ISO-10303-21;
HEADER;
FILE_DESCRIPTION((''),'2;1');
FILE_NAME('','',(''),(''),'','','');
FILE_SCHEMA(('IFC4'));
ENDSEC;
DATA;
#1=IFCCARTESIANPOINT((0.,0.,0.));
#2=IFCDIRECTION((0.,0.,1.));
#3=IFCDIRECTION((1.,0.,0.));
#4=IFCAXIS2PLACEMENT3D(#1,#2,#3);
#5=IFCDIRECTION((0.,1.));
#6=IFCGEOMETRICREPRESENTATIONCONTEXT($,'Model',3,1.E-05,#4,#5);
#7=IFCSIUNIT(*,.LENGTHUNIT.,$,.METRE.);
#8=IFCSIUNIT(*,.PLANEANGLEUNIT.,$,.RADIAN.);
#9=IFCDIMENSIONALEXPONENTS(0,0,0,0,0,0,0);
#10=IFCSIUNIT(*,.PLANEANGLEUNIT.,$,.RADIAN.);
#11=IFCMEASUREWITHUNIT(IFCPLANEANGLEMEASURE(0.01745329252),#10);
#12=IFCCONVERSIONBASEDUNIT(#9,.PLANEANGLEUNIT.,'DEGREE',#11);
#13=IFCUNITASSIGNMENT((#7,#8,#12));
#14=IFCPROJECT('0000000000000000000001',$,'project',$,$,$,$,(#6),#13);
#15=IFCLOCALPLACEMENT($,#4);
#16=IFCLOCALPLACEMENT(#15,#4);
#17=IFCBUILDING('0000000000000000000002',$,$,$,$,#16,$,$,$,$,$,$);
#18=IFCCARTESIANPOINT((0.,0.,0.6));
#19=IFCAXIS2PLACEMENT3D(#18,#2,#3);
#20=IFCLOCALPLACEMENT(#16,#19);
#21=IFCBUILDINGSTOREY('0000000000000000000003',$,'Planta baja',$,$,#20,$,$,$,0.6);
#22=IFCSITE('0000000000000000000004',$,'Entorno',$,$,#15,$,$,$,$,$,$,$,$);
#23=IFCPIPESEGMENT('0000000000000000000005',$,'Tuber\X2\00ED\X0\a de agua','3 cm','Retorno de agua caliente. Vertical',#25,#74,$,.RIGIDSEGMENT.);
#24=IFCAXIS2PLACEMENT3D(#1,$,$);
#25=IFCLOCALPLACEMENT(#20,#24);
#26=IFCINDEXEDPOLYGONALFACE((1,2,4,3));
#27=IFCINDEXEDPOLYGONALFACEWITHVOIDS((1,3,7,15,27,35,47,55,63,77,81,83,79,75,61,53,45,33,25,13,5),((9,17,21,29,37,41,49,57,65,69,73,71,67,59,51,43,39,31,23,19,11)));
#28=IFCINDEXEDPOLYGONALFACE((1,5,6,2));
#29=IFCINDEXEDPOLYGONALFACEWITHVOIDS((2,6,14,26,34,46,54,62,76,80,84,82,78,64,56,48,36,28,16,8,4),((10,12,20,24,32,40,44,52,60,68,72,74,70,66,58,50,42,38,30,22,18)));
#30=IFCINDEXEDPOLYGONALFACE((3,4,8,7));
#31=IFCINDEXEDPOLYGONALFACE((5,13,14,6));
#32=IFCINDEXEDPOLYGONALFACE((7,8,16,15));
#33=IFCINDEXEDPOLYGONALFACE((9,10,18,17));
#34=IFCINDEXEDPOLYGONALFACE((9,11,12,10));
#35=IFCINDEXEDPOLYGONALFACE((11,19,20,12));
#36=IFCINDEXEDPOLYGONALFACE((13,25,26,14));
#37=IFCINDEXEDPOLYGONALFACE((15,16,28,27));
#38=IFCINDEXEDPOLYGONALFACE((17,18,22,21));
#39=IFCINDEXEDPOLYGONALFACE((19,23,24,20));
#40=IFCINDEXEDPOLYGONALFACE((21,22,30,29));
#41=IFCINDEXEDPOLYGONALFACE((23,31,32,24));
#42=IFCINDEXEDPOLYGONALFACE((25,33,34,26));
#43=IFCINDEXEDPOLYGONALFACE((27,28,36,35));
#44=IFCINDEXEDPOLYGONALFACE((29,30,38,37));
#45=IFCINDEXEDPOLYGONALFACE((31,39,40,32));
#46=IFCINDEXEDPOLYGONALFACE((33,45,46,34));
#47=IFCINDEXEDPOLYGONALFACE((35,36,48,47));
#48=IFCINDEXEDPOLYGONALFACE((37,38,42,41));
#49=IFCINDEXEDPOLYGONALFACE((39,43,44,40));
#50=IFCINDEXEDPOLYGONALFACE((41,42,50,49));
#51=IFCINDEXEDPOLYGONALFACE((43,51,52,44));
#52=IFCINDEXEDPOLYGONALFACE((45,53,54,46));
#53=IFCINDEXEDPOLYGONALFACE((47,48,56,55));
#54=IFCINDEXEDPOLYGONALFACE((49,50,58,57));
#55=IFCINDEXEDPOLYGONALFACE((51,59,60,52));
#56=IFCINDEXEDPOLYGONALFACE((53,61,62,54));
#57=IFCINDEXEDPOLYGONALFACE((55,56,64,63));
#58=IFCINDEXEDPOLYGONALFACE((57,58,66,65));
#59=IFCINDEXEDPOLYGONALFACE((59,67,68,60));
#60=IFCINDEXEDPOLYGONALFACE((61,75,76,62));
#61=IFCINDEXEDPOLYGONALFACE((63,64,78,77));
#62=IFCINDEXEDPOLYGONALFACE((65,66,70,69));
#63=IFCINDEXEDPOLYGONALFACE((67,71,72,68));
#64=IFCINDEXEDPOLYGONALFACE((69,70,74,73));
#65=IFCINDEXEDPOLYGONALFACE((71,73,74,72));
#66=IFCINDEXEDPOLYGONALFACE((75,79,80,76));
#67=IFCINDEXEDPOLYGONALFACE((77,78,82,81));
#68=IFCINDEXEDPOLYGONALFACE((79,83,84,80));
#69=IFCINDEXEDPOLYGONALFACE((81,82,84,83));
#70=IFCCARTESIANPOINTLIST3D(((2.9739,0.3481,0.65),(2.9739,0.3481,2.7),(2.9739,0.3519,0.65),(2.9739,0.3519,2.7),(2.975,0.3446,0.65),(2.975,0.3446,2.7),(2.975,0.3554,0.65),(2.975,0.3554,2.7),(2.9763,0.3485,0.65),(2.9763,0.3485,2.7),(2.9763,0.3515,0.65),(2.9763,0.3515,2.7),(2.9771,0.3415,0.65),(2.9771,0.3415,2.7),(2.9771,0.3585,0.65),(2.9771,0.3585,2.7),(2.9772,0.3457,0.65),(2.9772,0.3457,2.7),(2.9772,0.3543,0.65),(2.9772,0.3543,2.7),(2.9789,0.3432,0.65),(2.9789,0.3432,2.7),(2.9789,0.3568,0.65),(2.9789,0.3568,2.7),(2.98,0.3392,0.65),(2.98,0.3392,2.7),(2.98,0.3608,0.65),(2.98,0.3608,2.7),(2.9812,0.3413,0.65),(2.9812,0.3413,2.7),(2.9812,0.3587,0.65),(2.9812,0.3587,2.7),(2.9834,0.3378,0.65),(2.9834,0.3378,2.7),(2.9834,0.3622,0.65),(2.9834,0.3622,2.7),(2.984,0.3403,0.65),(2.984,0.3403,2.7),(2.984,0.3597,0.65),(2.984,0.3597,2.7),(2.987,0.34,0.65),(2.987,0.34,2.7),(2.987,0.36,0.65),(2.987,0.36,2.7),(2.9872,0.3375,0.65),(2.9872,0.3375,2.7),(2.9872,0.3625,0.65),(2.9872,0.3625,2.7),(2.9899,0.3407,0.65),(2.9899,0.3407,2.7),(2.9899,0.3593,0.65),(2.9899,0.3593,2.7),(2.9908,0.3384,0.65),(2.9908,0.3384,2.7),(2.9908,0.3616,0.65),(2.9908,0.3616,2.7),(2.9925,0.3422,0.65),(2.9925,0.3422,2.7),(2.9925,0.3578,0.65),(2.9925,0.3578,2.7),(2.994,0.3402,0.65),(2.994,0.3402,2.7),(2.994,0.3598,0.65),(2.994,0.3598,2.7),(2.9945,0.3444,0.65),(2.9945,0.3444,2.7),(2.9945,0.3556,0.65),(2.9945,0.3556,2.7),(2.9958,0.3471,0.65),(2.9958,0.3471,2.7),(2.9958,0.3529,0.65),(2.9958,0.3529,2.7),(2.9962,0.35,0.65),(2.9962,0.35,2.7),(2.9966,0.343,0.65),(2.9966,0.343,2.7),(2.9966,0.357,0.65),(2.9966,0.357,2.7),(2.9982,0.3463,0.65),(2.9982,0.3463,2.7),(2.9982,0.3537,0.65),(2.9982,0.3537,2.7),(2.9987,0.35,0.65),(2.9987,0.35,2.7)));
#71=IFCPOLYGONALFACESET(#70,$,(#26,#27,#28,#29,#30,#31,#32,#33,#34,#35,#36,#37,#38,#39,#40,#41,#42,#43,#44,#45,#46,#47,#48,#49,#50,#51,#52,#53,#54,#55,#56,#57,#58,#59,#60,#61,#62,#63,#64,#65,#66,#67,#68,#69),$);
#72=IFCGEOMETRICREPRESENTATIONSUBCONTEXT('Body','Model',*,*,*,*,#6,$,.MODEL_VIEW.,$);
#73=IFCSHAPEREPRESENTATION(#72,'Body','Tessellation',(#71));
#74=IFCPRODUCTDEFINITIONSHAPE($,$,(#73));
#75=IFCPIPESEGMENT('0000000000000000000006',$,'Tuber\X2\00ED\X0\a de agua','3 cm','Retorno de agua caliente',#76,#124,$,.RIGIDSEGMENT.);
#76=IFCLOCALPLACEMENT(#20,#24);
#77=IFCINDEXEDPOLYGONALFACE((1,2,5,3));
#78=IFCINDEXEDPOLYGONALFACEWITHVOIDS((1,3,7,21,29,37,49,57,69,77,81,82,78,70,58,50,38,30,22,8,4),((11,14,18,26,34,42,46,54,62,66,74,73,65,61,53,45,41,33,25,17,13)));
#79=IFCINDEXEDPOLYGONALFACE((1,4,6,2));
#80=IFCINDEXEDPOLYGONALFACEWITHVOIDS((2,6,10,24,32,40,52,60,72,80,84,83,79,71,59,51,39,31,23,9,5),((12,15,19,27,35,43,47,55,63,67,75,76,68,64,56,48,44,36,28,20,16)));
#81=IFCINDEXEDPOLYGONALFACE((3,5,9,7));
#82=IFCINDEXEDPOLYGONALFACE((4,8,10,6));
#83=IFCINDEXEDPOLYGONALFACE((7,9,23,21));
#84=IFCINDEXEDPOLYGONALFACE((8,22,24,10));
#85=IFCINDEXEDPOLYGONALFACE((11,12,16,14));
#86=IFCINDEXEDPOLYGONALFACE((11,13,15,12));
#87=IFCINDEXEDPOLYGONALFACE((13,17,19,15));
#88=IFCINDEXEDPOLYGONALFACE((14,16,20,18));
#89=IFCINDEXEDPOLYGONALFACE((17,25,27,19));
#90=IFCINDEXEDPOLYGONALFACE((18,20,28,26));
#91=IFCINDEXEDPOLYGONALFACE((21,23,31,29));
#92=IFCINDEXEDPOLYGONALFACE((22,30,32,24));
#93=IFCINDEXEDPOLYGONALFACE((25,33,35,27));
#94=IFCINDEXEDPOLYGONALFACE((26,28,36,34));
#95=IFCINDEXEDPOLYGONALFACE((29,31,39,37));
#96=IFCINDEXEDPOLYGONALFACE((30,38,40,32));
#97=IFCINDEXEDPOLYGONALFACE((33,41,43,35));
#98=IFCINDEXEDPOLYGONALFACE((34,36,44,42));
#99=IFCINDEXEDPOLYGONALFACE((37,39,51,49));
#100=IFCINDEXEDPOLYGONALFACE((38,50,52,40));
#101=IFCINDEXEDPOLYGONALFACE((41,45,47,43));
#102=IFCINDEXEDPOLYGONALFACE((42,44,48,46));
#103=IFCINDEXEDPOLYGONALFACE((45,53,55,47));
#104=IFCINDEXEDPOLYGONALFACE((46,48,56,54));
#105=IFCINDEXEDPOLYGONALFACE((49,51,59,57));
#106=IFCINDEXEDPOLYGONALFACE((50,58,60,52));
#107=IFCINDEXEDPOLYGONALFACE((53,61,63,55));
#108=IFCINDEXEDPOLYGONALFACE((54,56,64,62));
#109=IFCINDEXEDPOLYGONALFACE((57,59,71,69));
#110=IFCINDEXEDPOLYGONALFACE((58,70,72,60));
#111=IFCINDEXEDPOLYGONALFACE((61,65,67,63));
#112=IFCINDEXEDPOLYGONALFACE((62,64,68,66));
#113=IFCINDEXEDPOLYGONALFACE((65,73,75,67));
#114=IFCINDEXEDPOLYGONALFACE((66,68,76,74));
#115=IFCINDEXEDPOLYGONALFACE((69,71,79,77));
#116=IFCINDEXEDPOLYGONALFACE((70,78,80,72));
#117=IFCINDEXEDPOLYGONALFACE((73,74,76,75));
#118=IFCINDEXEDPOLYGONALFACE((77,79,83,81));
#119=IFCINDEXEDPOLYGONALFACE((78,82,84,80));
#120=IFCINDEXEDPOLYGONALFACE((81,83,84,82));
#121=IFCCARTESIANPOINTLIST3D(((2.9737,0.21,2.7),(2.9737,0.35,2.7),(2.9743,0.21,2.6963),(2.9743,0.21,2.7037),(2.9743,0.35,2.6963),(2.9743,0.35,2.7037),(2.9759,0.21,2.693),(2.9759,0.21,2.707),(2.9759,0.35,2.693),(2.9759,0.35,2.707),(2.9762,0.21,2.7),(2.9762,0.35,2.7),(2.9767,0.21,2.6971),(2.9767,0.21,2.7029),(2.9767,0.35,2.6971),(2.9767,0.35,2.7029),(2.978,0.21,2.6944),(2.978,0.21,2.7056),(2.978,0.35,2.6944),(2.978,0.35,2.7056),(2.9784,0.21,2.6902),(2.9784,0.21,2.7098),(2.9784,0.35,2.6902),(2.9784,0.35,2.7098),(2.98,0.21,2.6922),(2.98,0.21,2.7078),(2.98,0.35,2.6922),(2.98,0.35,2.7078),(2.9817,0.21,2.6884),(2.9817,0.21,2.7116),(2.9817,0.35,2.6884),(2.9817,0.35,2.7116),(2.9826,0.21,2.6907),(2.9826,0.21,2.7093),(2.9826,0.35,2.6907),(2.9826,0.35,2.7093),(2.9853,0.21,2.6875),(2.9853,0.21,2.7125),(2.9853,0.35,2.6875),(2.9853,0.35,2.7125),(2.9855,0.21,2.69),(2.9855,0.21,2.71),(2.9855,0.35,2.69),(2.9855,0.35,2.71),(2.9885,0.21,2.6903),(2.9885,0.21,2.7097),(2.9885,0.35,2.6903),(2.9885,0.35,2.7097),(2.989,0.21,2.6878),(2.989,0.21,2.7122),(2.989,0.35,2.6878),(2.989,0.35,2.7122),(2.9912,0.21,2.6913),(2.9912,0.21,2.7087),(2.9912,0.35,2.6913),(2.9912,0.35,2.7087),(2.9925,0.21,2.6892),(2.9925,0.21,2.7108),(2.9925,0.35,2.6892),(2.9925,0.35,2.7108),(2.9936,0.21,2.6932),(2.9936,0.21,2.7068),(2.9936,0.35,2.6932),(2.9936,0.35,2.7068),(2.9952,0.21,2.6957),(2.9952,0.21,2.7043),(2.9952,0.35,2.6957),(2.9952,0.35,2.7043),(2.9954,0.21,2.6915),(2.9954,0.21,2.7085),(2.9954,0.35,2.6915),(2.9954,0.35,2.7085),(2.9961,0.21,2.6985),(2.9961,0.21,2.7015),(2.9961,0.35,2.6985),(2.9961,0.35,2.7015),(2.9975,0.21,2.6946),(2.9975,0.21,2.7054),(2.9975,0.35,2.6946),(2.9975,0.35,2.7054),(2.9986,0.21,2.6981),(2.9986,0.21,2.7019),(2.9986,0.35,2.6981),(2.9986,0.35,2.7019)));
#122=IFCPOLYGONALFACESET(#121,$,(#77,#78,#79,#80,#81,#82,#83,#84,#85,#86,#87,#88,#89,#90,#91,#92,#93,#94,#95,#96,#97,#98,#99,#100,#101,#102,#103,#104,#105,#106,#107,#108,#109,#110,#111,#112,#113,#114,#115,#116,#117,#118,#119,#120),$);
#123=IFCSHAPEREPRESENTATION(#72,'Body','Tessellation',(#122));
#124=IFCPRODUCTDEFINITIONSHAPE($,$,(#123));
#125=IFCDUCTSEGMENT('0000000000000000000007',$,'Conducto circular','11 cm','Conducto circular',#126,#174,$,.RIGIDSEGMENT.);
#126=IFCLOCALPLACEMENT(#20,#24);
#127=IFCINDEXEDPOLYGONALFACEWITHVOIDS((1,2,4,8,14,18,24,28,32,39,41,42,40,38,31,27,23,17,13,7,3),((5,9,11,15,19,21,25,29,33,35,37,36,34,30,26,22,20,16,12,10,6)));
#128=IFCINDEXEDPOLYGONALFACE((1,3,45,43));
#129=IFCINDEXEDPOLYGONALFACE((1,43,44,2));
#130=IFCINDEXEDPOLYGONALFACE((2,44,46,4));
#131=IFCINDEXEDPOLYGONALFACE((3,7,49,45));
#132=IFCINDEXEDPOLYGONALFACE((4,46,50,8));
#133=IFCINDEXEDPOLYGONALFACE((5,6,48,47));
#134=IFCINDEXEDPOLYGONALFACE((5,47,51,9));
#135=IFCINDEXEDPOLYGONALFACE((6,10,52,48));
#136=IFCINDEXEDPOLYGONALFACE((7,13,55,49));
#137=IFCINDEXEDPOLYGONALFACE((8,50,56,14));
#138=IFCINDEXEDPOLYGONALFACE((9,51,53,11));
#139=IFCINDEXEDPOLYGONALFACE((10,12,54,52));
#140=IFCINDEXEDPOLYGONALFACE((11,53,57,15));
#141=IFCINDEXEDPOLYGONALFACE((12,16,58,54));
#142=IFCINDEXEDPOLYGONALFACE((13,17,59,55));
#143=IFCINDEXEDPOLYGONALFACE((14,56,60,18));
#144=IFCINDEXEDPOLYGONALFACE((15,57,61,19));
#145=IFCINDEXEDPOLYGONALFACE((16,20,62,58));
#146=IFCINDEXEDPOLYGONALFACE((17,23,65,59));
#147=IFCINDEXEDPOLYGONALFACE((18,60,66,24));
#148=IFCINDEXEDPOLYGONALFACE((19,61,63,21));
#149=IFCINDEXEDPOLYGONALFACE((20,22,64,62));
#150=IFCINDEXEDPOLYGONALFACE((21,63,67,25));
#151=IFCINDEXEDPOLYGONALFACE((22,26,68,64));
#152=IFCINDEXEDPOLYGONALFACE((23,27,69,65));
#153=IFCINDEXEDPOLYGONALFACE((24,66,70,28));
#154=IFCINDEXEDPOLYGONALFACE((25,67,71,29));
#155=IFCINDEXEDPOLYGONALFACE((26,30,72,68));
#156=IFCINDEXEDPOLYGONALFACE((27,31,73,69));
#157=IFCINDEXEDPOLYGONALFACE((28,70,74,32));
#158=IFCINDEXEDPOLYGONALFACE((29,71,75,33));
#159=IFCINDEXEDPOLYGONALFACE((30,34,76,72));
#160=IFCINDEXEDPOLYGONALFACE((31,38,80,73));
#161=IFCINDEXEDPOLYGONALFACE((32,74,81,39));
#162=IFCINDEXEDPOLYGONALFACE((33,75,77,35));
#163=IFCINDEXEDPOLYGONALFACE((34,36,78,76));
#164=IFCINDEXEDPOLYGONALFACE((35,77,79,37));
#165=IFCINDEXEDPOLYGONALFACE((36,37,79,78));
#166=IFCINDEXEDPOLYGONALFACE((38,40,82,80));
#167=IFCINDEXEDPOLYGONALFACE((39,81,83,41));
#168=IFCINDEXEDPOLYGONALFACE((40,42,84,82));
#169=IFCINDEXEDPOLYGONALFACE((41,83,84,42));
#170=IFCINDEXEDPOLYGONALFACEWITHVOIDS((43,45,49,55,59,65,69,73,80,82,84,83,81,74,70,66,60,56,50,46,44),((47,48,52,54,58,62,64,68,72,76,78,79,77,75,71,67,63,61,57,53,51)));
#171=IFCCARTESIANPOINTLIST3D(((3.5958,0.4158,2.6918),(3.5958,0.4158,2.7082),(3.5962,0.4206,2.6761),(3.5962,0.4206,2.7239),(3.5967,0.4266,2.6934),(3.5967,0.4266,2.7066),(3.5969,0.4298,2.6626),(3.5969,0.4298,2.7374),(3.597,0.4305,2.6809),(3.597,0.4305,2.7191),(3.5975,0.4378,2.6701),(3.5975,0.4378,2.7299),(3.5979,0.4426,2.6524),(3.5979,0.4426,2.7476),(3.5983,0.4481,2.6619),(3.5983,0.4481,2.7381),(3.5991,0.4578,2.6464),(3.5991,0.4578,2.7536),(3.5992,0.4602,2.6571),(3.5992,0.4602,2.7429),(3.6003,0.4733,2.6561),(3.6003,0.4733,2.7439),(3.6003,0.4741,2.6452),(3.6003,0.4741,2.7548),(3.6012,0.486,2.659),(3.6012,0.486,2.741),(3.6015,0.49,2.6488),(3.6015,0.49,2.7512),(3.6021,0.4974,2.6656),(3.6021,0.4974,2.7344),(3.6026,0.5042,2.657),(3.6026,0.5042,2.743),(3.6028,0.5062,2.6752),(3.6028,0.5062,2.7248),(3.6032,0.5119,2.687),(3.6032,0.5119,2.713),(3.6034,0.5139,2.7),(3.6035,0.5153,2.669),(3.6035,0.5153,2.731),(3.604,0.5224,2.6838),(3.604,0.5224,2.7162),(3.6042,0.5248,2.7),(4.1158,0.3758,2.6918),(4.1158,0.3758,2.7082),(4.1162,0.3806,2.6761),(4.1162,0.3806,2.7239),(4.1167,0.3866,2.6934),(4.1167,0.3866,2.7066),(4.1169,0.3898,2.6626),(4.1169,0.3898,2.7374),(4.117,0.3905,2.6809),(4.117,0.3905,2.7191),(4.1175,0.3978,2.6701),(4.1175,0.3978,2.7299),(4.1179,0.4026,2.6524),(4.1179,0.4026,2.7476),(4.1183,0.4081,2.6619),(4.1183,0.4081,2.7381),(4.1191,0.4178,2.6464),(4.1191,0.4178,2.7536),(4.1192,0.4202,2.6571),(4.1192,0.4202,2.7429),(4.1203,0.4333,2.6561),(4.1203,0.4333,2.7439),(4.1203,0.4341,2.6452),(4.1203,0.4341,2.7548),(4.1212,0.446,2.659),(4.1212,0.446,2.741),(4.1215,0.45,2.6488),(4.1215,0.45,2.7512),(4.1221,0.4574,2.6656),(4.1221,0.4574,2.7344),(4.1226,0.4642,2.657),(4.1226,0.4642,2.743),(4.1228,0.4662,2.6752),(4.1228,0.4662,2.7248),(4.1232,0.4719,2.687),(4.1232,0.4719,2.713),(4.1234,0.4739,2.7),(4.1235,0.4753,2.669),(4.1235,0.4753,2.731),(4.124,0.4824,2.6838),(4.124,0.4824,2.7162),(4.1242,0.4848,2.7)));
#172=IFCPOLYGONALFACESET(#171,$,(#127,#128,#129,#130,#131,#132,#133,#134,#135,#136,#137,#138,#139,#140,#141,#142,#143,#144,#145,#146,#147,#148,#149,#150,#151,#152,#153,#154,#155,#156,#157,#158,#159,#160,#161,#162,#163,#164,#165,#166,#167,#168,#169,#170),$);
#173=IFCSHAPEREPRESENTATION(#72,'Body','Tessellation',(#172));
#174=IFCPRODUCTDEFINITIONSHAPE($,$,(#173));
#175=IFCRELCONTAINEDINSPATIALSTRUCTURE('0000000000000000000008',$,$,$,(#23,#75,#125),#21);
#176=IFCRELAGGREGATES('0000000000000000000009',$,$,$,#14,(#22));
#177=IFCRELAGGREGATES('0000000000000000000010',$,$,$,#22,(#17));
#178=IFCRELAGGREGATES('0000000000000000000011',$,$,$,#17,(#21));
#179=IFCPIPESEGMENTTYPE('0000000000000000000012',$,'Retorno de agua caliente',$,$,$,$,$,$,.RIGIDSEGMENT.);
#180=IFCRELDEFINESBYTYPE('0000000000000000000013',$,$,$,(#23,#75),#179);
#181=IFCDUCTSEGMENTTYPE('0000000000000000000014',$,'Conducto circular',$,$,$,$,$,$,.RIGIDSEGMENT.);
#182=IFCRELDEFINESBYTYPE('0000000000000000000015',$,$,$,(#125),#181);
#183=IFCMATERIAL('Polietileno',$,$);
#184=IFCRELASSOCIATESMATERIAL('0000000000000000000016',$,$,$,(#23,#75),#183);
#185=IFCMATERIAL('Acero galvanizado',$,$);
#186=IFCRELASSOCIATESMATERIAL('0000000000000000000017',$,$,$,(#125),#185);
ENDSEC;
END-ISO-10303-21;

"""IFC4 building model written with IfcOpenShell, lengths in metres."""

from ifc_helpers import new_model, entity, si_unit, converted_unit, direction, frame, origin_with_axes, origin_2d_with_axis, place, context, subcontext, project, spatial, hollow_circle, extrude, material, type_object, element, save


model = new_model("IFC4")

# Units and contexts
model_context = context("Model", 3, precision=1e-05, world=origin_with_axes(), true_north=direction((0.0, 1.0)))
body_context = subcontext(model_context, "Body", "Model", "MODEL_VIEW")
ifc_project = project(units=[si_unit("LENGTHUNIT", "METRE"), si_unit("PLANEANGLEUNIT", "RADIAN"), converted_unit("PLANEANGLEUNIT", "DEGREE", entity("IfcPlaneAngleMeasure", 0.01745329252), si_unit("PLANEANGLEUNIT", "RADIAN"), dimensions=[0, 0, 0, 0, 0, 0, 0])], contexts=[model_context])

# Site, building, storey
site_placement = place(None, origin_with_axes())
site = spatial("IfcSite", under=ifc_project, at=site_placement, Name="Entorno")
building_placement = place(site_placement, origin_with_axes())
building = spatial("IfcBuilding", under=site, at=building_placement)
storey_placement = place(building_placement, frame((0.0, 0.0, 0.6), z_axis=(0.0, 0.0, 1.0), x_axis=(1.0, 0.0, 0.0)))
storey = spatial("IfcBuildingStorey", under=building, at=storey_placement, Name="Planta baja", Elevation=0.6)

# Pipe segments
ifc_material_1 = material(Name="Polietileno")
pipe_segment_type_1 = type_object("IfcPipeSegmentType", Name="Retorno de agua caliente", PredefinedType="RIGIDSEGMENT")
pipe_segment_1_placement = place(storey_placement, frame((2.9862, 0.35, 2.7), z_axis=(0.0, 0.0, -1.0), x_axis=(1.0, 0.0, 0.0)))
element("IfcPipeSegment", 1, at=pipe_segment_1_placement, inside=storey, type_object=pipe_segment_type_1, material=ifc_material_1, Name="Tubería de agua", Description="3 cm", ObjectType="Retorno de agua caliente. Vertical", PredefinedType="RIGIDSEGMENT", context=body_context, shape_type="SweptSolid", body=[
    extrude(hollow_circle(Radius=0.0125, WallThickness=0.0025, at=origin_2d_with_axis()), origin_with_axes(), (0.0, 0.0, 1.0), 2.05),
])
pipe_segment_2_placement = place(storey_placement, frame((2.9862, 0.21, 2.7), z_axis=(0.0, 1.0, 0.0), x_axis=(-1.0, 0.0, 0.0)))
element("IfcPipeSegment", 2, at=pipe_segment_2_placement, inside=storey, type_object=pipe_segment_type_1, material=ifc_material_1, Name="Tubería de agua", Description="3 cm", ObjectType="Retorno de agua caliente", PredefinedType="RIGIDSEGMENT", context=body_context, shape_type="SweptSolid", body=[
    extrude(hollow_circle(Radius=0.0125, WallThickness=0.0025, at=origin_2d_with_axis()), origin_with_axes(), (0.0, 0.0, 1.0), 0.14),
])

# Duct segment
ifc_material_2 = material(Name="Acero galvanizado")
duct_segment_type = type_object("IfcDuctSegmentType", Name="Conducto circular", PredefinedType="RIGIDSEGMENT")
duct_segment_1_placement = place(storey_placement, frame((3.6, 0.47, 2.7), z_axis=(0.997054, -0.076696, 0.0), x_axis=(0.076696, 0.997054, 0.0)))
element("IfcDuctSegment", 3, at=duct_segment_1_placement, inside=storey, type_object=duct_segment_type, material=ifc_material_2, Name="Conducto circular", Description="11 cm", ObjectType="Conducto circular", PredefinedType="RIGIDSEGMENT", context=body_context, shape_type="SweptSolid", body=[
    extrude(hollow_circle(Radius=0.055, WallThickness=0.011, at=origin_2d_with_axis()), origin_with_axes(), (0.0, 0.0, 1.0), 0.5215),
])

save(model, "model.ifc")
